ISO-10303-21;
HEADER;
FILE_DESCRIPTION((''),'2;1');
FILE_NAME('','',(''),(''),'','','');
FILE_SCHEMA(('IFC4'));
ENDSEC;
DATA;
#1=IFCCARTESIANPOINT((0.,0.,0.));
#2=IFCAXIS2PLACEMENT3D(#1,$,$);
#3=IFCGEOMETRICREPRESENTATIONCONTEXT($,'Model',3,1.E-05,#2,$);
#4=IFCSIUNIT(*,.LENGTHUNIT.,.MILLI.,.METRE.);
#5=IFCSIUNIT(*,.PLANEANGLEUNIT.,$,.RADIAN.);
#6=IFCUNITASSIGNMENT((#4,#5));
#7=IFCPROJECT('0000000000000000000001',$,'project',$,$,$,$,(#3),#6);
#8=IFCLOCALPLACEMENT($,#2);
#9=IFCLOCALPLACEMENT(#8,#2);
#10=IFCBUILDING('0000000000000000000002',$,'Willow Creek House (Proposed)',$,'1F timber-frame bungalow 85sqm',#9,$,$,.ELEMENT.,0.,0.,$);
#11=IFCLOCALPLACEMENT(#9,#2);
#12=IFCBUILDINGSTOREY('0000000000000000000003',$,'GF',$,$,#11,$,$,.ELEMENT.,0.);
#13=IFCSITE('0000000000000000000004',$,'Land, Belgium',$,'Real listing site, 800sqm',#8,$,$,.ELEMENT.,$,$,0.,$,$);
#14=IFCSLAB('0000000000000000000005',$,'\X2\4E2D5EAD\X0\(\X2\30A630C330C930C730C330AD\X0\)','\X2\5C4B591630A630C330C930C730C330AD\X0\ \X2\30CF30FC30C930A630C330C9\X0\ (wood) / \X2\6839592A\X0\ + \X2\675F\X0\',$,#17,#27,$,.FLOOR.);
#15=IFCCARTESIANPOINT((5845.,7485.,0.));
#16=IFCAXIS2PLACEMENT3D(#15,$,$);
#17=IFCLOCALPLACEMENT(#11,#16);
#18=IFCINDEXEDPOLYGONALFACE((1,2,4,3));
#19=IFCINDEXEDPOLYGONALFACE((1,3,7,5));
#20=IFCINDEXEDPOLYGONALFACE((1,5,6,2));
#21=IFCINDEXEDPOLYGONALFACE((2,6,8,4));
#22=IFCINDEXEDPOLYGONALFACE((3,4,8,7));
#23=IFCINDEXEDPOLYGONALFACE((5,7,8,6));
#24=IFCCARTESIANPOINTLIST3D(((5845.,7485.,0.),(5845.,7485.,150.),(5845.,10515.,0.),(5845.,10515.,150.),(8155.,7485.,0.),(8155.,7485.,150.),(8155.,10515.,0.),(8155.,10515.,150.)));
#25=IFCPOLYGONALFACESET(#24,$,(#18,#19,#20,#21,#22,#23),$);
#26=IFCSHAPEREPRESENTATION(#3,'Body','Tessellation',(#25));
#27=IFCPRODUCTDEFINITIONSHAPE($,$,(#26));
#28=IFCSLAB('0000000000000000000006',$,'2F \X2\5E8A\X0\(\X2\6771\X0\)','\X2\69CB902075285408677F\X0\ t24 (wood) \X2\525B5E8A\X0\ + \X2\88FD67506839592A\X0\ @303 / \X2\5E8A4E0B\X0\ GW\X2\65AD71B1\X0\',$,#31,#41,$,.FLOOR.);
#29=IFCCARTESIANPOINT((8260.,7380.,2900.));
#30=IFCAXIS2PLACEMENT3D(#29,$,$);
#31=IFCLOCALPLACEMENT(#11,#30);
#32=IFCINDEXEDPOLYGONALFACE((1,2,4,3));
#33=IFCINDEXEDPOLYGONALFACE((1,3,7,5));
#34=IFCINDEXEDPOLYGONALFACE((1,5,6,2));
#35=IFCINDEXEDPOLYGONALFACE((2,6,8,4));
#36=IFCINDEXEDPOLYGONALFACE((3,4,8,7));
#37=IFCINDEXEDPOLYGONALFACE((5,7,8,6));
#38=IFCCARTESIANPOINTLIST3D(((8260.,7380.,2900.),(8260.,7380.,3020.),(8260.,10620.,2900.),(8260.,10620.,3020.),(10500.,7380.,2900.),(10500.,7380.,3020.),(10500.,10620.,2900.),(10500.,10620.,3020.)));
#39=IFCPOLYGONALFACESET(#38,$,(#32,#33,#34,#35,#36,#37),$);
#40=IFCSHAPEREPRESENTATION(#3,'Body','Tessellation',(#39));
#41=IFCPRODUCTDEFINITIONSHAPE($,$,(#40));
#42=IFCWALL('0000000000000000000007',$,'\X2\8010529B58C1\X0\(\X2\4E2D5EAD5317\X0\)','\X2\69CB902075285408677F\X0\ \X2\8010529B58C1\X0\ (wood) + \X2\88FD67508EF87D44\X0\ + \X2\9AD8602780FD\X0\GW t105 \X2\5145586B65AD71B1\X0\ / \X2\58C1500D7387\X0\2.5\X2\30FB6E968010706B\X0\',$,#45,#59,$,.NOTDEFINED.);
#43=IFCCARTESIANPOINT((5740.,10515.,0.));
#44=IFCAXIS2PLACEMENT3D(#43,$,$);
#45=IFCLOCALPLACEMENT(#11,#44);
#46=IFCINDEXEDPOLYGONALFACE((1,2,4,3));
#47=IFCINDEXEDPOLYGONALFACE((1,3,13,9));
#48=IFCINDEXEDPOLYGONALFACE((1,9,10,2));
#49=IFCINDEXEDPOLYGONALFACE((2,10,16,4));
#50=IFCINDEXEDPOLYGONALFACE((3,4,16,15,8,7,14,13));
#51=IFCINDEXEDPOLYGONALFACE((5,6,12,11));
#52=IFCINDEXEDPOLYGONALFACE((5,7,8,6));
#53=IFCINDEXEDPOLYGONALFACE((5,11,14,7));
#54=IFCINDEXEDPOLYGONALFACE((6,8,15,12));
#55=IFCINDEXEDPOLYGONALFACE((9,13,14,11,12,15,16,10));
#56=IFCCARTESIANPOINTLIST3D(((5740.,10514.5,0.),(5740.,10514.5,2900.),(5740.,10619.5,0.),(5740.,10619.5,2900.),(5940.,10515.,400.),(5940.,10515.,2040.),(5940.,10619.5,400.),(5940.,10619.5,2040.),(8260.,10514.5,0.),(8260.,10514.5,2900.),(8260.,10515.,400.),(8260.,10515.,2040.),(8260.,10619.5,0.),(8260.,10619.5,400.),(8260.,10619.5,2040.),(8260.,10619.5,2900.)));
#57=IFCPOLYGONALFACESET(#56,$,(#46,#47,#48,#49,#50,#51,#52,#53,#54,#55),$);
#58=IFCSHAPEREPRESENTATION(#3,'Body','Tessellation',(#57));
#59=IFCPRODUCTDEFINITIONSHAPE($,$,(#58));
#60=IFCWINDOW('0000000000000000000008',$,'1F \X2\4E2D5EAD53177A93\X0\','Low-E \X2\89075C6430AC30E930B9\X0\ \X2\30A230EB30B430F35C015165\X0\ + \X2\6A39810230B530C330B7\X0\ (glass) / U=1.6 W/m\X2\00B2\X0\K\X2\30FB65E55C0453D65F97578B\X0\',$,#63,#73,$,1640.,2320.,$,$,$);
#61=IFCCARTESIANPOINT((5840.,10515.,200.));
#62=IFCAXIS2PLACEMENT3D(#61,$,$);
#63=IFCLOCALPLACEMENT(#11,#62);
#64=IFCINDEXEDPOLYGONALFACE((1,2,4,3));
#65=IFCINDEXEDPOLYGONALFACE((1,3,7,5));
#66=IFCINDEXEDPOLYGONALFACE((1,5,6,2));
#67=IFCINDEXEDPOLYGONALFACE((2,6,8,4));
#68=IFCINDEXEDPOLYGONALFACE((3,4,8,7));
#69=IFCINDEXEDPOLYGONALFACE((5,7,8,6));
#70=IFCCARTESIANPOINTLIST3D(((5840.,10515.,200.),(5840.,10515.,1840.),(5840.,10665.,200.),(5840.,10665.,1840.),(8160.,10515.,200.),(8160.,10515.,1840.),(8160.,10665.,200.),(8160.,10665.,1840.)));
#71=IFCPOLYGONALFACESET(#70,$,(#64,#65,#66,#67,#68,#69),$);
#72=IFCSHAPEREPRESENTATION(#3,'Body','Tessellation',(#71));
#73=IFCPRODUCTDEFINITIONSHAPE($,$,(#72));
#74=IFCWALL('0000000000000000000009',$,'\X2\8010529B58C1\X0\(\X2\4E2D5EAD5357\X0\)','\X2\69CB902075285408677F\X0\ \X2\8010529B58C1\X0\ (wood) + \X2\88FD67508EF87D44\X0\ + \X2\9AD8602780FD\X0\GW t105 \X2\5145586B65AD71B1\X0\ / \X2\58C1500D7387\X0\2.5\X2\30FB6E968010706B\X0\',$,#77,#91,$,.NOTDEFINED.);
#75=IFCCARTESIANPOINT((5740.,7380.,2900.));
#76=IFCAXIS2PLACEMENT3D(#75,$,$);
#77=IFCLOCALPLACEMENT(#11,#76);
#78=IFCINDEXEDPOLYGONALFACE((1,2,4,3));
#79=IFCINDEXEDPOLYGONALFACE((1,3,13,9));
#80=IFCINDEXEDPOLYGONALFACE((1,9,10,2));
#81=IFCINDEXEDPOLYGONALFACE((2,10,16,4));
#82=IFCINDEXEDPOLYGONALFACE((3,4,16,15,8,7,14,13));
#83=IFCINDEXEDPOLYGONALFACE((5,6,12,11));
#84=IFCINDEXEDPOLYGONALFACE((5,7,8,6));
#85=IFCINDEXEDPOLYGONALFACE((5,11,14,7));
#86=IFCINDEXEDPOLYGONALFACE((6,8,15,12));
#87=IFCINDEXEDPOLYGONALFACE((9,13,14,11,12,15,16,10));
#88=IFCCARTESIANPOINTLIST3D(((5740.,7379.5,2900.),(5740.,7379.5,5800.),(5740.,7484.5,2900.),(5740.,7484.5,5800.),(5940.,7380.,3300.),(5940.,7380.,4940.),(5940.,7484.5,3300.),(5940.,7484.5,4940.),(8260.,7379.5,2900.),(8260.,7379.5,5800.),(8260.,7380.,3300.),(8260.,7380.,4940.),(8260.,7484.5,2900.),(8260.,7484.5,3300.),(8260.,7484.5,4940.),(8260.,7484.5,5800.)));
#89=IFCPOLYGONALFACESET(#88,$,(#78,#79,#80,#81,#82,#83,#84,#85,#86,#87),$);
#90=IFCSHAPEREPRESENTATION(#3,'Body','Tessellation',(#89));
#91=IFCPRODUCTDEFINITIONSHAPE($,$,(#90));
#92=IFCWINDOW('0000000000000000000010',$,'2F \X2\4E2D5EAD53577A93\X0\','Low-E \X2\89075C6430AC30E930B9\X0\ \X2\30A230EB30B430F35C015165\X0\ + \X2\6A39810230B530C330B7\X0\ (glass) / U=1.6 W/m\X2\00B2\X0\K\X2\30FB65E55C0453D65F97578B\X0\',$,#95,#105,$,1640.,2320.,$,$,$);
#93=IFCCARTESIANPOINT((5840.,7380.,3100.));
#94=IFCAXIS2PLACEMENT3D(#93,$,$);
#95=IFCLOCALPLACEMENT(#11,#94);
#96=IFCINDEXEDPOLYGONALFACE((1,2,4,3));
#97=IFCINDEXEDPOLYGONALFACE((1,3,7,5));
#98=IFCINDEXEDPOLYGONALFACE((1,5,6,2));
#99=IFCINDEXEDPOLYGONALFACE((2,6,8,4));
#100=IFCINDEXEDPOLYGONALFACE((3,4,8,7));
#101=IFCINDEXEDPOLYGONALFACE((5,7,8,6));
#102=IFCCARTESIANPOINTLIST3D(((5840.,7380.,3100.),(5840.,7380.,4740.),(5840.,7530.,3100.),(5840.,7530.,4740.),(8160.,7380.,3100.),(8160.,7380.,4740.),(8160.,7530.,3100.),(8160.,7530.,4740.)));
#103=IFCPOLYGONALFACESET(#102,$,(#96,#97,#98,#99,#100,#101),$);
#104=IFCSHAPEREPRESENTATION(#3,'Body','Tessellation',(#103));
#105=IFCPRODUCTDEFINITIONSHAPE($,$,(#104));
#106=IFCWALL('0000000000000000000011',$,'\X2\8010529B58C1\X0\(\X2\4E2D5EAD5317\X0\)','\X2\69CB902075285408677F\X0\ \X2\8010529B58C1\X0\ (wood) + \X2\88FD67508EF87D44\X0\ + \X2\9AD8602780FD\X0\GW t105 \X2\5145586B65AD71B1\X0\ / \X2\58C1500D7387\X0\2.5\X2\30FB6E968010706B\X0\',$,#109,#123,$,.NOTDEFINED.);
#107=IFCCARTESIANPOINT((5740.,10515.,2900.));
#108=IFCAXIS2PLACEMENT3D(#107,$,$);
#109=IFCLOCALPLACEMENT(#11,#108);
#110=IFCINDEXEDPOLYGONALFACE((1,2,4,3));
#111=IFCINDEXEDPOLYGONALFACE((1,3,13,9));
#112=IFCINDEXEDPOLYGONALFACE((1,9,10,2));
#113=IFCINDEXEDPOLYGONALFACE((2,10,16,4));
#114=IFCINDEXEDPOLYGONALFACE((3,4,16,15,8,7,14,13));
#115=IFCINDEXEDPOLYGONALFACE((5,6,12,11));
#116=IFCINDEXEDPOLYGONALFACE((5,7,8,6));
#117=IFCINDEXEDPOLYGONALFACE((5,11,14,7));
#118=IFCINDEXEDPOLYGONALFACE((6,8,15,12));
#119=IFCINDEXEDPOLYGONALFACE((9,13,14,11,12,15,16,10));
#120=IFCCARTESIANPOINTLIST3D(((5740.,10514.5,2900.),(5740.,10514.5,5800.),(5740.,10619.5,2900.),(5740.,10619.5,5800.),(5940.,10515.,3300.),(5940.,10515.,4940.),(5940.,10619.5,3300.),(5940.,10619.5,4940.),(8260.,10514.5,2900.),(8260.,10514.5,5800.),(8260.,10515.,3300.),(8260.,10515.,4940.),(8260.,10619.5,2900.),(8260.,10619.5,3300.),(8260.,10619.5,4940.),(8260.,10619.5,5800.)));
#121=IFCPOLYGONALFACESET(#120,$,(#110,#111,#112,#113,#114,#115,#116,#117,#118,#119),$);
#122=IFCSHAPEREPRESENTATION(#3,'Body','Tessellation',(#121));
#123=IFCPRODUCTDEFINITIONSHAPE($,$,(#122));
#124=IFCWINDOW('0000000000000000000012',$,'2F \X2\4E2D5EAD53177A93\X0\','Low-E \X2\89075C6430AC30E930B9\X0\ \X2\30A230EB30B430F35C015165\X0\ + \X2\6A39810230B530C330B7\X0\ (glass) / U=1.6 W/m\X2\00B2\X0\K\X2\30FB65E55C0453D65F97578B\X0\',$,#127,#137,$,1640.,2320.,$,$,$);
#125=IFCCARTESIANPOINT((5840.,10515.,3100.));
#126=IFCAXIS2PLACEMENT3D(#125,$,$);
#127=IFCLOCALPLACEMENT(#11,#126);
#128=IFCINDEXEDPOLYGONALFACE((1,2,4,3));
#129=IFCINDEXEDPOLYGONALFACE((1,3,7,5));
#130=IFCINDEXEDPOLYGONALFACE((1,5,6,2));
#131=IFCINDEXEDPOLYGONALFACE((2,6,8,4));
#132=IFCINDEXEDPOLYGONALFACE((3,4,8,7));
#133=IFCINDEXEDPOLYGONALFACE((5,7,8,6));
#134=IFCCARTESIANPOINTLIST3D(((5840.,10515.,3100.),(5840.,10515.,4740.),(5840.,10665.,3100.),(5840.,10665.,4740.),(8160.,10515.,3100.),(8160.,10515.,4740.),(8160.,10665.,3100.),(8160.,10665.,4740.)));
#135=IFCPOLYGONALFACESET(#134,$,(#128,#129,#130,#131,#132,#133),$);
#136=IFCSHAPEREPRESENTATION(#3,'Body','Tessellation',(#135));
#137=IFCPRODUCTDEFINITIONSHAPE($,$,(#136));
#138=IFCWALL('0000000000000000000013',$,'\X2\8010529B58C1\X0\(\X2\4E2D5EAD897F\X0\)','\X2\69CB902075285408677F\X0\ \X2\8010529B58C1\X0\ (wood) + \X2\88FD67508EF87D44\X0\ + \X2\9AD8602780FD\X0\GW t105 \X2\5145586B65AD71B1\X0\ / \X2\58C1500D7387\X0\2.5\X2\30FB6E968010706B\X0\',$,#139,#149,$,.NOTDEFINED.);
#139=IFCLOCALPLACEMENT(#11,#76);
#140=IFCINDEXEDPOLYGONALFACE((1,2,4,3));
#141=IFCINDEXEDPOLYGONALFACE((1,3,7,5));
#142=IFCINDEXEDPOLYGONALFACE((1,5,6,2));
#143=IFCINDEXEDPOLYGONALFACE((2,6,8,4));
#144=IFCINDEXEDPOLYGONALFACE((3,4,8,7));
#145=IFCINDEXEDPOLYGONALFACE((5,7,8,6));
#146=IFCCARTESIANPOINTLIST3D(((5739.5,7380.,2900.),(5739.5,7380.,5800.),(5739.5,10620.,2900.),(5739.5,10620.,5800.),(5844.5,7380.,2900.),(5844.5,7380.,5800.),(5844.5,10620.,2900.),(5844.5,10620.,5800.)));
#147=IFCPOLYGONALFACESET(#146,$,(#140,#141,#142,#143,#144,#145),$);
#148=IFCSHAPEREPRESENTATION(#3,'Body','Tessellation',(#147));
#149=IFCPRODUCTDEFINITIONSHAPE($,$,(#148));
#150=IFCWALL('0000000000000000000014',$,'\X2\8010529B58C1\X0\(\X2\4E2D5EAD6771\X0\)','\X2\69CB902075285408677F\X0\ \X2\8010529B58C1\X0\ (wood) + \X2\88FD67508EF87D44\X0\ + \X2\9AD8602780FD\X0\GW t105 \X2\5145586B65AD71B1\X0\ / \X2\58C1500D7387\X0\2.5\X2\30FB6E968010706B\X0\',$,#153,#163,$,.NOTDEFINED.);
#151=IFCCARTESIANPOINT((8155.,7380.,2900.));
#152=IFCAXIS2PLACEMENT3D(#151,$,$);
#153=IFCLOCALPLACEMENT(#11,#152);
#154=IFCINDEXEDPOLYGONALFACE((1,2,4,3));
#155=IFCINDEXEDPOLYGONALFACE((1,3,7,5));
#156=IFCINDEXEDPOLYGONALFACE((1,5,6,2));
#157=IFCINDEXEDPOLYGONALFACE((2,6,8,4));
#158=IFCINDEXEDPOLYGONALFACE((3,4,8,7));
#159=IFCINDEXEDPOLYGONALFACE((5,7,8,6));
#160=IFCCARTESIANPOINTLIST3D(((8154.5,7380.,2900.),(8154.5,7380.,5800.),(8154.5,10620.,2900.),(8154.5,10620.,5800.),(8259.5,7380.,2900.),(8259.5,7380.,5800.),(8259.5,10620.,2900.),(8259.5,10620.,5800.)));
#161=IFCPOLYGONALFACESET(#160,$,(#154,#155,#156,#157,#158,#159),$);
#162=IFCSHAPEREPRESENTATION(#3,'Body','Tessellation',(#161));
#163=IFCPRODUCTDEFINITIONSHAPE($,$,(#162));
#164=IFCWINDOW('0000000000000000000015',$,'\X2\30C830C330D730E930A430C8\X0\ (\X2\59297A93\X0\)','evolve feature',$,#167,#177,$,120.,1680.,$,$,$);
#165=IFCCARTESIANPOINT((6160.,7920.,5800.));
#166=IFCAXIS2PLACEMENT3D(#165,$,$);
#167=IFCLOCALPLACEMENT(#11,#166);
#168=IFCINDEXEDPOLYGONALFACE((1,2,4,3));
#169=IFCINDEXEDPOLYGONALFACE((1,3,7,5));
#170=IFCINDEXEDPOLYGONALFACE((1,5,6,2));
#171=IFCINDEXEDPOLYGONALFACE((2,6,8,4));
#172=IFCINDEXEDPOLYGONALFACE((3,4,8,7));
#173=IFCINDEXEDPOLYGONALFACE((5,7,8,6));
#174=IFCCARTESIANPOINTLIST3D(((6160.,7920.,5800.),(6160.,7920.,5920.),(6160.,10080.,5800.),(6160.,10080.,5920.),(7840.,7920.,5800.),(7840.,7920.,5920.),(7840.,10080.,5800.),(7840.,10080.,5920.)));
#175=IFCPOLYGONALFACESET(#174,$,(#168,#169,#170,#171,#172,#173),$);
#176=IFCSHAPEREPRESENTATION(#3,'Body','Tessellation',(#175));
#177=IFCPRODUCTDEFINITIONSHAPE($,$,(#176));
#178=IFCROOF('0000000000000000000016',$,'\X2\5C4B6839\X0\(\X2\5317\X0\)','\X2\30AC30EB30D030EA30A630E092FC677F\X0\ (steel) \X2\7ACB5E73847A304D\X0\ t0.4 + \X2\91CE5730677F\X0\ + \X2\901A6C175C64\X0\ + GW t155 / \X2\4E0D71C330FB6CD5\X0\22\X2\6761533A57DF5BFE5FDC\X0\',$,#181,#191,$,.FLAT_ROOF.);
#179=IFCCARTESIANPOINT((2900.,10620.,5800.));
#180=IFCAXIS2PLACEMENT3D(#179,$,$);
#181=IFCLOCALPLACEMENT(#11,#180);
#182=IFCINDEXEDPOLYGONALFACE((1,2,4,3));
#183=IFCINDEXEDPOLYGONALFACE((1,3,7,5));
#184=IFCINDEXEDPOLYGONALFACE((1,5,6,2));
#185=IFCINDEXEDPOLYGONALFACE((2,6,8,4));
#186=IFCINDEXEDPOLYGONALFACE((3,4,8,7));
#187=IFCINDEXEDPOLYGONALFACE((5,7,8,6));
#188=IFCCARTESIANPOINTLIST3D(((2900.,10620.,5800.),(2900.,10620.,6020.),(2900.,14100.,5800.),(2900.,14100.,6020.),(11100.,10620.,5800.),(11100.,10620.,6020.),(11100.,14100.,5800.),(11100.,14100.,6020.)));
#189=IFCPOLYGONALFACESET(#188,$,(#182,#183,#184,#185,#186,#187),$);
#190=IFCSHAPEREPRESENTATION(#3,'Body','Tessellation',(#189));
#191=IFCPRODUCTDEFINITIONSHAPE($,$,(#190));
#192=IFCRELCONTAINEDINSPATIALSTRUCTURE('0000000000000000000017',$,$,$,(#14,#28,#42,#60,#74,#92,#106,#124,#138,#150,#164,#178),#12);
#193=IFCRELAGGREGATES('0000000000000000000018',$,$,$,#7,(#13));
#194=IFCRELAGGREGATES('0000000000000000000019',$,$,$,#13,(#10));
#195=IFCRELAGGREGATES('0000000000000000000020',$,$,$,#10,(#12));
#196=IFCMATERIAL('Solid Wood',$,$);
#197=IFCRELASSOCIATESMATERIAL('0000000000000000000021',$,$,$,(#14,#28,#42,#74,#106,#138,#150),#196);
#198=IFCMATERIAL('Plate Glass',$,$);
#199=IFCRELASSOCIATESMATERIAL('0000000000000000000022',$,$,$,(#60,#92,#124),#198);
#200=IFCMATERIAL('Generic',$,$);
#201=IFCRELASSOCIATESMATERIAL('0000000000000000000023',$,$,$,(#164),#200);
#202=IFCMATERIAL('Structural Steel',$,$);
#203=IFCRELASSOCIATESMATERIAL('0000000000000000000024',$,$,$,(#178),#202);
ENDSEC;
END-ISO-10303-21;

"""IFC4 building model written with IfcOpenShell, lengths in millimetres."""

from ifc_helpers import new_model, si_unit, frame, frame_2d, origin, place, context, project, spatial, rectangle, extrude, material, element, fill, save


model = new_model("IFC4")

# Units and contexts
model_context = context("Model", 3, precision=1e-05, world=origin())
ifc_project = project(units=[si_unit("LENGTHUNIT", "METRE", prefix="MILLI"), si_unit("PLANEANGLEUNIT", "RADIAN")], contexts=[model_context])

# Site, building, storey
site_placement = place(None, origin())
site = spatial("IfcSite", under=ifc_project, at=site_placement, Name="Land, Belgium", ObjectType="Real listing site, 800sqm", CompositionType="ELEMENT", RefElevation=0.0)
building_placement = place(site_placement, origin())
building = spatial("IfcBuilding", under=site, at=building_placement, Name="Willow Creek House (Proposed)", ObjectType="1F timber-frame bungalow 85sqm", CompositionType="ELEMENT", ElevationOfRefHeight=0.0, ElevationOfTerrain=0.0)
storey_placement = place(building_placement, origin())
storey = spatial("IfcBuildingStorey", under=building, at=storey_placement, Name="GF", CompositionType="ELEMENT", Elevation=0.0)

# Slabs
ifc_material_1 = material(Name="Solid Wood")
slab_1_placement = place(storey_placement, frame((5845.0, 7485.0, 0.0)))
element("IfcSlab", 1, at=slab_1_placement, inside=storey, material=ifc_material_1, Name="中庭(ウッドデッキ)", Description="屋外ウッドデッキ ハードウッド (wood) / 根太 + 束", PredefinedType="FLOOR", context=model_context, shape_type="SweptSolid", body=[
    extrude(rectangle(XDim=2310.0, YDim=3030.0, at=frame_2d((1155.0, 1515.0))), frame((5845.0, 7485.0, 0.0)), (0.0, 0.0, 1.0), 150.0),
])
slab_2_placement = place(storey_placement, frame((8260.0, 7380.0, 2900.0)))
element("IfcSlab", 2, at=slab_2_placement, inside=storey, material=ifc_material_1, Name="2F 床(東)", Description="構造用合板 t24 (wood) 剛床 + 製材根太 @303 / 床下 GW断熱", PredefinedType="FLOOR", context=model_context, shape_type="SweptSolid", body=[
    extrude(rectangle(XDim=2240.0, YDim=3240.0, at=frame_2d((1120.0, 1620.0))), frame((8260.0, 7380.0, 2900.0)), (0.0, 0.0, 1.0), 120.0),
])

# Walls, openings, windows
wall_1_placement = place(storey_placement, frame((5740.0, 10515.0, 0.0)))
wall_1 = element("IfcWall", 3, at=wall_1_placement, inside=storey, material=ifc_material_1, Name="耐力壁(中庭北)", Description="構造用合板 耐力壁 (wood) + 製材軸組 + 高性能GW t105 充填断熱 / 壁倍率2.5・準耐火", PredefinedType="NOTDEFINED", context=model_context, shape_type="SweptSolid", body=[
    extrude(rectangle(XDim=2520.0, YDim=105.0, at=frame_2d((1260.0, 52.0))), frame((5740.0, 10515.0, 0.0)), (0.0, 0.0, 1.0), 2900.0),
])
opening_1_placement = place(storey_placement, frame((5840.0, 10515.0, 200.0)))
opening_1 = element("IfcOpeningElement", 4, at=opening_1_placement, cuts=wall_1, PredefinedType="NOTDEFINED", context=model_context, shape_type="SweptSolid", body=[
    extrude(rectangle(XDim=2320.0, YDim=150.0, at=frame_2d((1160.0, 75.0))), frame((5840.0, 10515.0, 200.0)), (0.0, 0.0, 1.0), 1640.0),
])
ifc_material_2 = material(Name="Plate Glass")
window_1_placement = place(storey_placement, frame((5840.0, 10515.0, 200.0)))
window_1 = element("IfcWindow", 5, at=window_1_placement, inside=storey, material=ifc_material_2, Name="1F 中庭北窓", Description="Low-E 複層ガラス アルゴン封入 + 樹脂サッシ (glass) / U=1.6 W/m²K・日射取得型", OverallHeight=1640.0, OverallWidth=2320.0, context=model_context, shape_type="SweptSolid", body=[
    extrude(rectangle(XDim=2320.0, YDim=150.0, at=frame_2d((1160.0, 75.0))), frame((5840.0, 10515.0, 200.0)), (0.0, 0.0, 1.0), 1640.0),
])
fill(opening_1, window_1)
wall_2_placement = place(storey_placement, frame((5740.0, 7380.0, 2900.0)))
wall_2 = element("IfcWall", 6, at=wall_2_placement, inside=storey, material=ifc_material_1, Name="耐力壁(中庭南)", Description="構造用合板 耐力壁 (wood) + 製材軸組 + 高性能GW t105 充填断熱 / 壁倍率2.5・準耐火", PredefinedType="NOTDEFINED", context=model_context, shape_type="SweptSolid", body=[
    extrude(rectangle(XDim=2520.0, YDim=105.0, at=frame_2d((1260.0, 52.0))), frame((5740.0, 7380.0, 2900.0)), (0.0, 0.0, 1.0), 2900.0),
])
opening_2_placement = place(storey_placement, frame((5840.0, 7380.0, 3100.0)))
opening_2 = element("IfcOpeningElement", 7, at=opening_2_placement, cuts=wall_2, PredefinedType="NOTDEFINED", context=model_context, shape_type="SweptSolid", body=[
    extrude(rectangle(XDim=2320.0, YDim=150.0, at=frame_2d((1160.0, 75.0))), frame((5840.0, 7380.0, 3100.0)), (0.0, 0.0, 1.0), 1640.0),
])
window_2_placement = place(storey_placement, frame((5840.0, 7380.0, 3100.0)))
window_2 = element("IfcWindow", 8, at=window_2_placement, inside=storey, material=ifc_material_2, Name="2F 中庭南窓", Description="Low-E 複層ガラス アルゴン封入 + 樹脂サッシ (glass) / U=1.6 W/m²K・日射取得型", OverallHeight=1640.0, OverallWidth=2320.0, context=model_context, shape_type="SweptSolid", body=[
    extrude(rectangle(XDim=2320.0, YDim=150.0, at=frame_2d((1160.0, 75.0))), frame((5840.0, 7380.0, 3100.0)), (0.0, 0.0, 1.0), 1640.0),
])
fill(opening_2, window_2)
wall_3_placement = place(storey_placement, frame((5740.0, 10515.0, 2900.0)))
wall_3 = element("IfcWall", 9, at=wall_3_placement, inside=storey, material=ifc_material_1, Name="耐力壁(中庭北)", Description="構造用合板 耐力壁 (wood) + 製材軸組 + 高性能GW t105 充填断熱 / 壁倍率2.5・準耐火", PredefinedType="NOTDEFINED", context=model_context, shape_type="SweptSolid", body=[
    extrude(rectangle(XDim=2520.0, YDim=105.0, at=frame_2d((1260.0, 52.0))), frame((5740.0, 10515.0, 2900.0)), (0.0, 0.0, 1.0), 2900.0),
])
opening_3_placement = place(storey_placement, frame((5840.0, 10515.0, 3100.0)))
opening_3 = element("IfcOpeningElement", 10, at=opening_3_placement, cuts=wall_3, PredefinedType="NOTDEFINED", context=model_context, shape_type="SweptSolid", body=[
    extrude(rectangle(XDim=2320.0, YDim=150.0, at=frame_2d((1160.0, 75.0))), frame((5840.0, 10515.0, 3100.0)), (0.0, 0.0, 1.0), 1640.0),
])
window_3_placement = place(storey_placement, frame((5840.0, 10515.0, 3100.0)))
window_3 = element("IfcWindow", 11, at=window_3_placement, inside=storey, material=ifc_material_2, Name="2F 中庭北窓", Description="Low-E 複層ガラス アルゴン封入 + 樹脂サッシ (glass) / U=1.6 W/m²K・日射取得型", OverallHeight=1640.0, OverallWidth=2320.0, context=model_context, shape_type="SweptSolid", body=[
    extrude(rectangle(XDim=2320.0, YDim=150.0, at=frame_2d((1160.0, 75.0))), frame((5840.0, 10515.0, 3100.0)), (0.0, 0.0, 1.0), 1640.0),
])
fill(opening_3, window_3)

# Walls
wall_4_placement = place(storey_placement, frame((5740.0, 7380.0, 2900.0)))
element("IfcWall", 12, at=wall_4_placement, inside=storey, material=ifc_material_1, Name="耐力壁(中庭西)", Description="構造用合板 耐力壁 (wood) + 製材軸組 + 高性能GW t105 充填断熱 / 壁倍率2.5・準耐火", PredefinedType="NOTDEFINED", context=model_context, shape_type="SweptSolid", body=[
    extrude(rectangle(XDim=105.0, YDim=3240.0, at=frame_2d((52.0, 1620.0))), frame((5740.0, 7380.0, 2900.0)), (0.0, 0.0, 1.0), 2900.0),
])
wall_5_placement = place(storey_placement, frame((8155.0, 7380.0, 2900.0)))
element("IfcWall", 13, at=wall_5_placement, inside=storey, material=ifc_material_1, Name="耐力壁(中庭東)", Description="構造用合板 耐力壁 (wood) + 製材軸組 + 高性能GW t105 充填断熱 / 壁倍率2.5・準耐火", PredefinedType="NOTDEFINED", context=model_context, shape_type="SweptSolid", body=[
    extrude(rectangle(XDim=105.0, YDim=3240.0, at=frame_2d((52.0, 1620.0))), frame((8155.0, 7380.0, 2900.0)), (0.0, 0.0, 1.0), 2900.0),
])

# Window
ifc_material_3 = material(Name="Generic")
window_4_placement = place(storey_placement, frame((6160.0, 7920.0, 5800.0)))
element("IfcWindow", 14, at=window_4_placement, inside=storey, material=ifc_material_3, Name="トップライト (天窓)", Description="evolve feature", OverallHeight=120.0, OverallWidth=1680.0, context=model_context, shape_type="SweptSolid", body=[
    extrude(rectangle(XDim=1680.0, YDim=2160.0, at=frame_2d((840.0, 1080.0))), frame((6160.0, 7920.0, 5800.0)), (0.0, 0.0, 1.0), 120.0),
])

# Roof
ifc_material_4 = material(Name="Structural Steel")
roof_1_placement = place(storey_placement, frame((2900.0, 10620.0, 5800.0)))
element("IfcRoof", 15, at=roof_1_placement, inside=storey, material=ifc_material_4, Name="屋根(北)", Description="ガルバリウム鋼板 (steel) 立平葺き t0.4 + 野地板 + 通気層 + GW t155 / 不燃・法22条区域対応", PredefinedType="FLAT_ROOF", context=model_context, shape_type="SweptSolid", body=[
    extrude(rectangle(XDim=8200.0, YDim=3480.0, at=frame_2d((4100.0, 1740.0))), frame((2900.0, 10620.0, 5800.0)), (0.0, 0.0, 1.0), 220.0),
])

save(model, "model.ifc")
